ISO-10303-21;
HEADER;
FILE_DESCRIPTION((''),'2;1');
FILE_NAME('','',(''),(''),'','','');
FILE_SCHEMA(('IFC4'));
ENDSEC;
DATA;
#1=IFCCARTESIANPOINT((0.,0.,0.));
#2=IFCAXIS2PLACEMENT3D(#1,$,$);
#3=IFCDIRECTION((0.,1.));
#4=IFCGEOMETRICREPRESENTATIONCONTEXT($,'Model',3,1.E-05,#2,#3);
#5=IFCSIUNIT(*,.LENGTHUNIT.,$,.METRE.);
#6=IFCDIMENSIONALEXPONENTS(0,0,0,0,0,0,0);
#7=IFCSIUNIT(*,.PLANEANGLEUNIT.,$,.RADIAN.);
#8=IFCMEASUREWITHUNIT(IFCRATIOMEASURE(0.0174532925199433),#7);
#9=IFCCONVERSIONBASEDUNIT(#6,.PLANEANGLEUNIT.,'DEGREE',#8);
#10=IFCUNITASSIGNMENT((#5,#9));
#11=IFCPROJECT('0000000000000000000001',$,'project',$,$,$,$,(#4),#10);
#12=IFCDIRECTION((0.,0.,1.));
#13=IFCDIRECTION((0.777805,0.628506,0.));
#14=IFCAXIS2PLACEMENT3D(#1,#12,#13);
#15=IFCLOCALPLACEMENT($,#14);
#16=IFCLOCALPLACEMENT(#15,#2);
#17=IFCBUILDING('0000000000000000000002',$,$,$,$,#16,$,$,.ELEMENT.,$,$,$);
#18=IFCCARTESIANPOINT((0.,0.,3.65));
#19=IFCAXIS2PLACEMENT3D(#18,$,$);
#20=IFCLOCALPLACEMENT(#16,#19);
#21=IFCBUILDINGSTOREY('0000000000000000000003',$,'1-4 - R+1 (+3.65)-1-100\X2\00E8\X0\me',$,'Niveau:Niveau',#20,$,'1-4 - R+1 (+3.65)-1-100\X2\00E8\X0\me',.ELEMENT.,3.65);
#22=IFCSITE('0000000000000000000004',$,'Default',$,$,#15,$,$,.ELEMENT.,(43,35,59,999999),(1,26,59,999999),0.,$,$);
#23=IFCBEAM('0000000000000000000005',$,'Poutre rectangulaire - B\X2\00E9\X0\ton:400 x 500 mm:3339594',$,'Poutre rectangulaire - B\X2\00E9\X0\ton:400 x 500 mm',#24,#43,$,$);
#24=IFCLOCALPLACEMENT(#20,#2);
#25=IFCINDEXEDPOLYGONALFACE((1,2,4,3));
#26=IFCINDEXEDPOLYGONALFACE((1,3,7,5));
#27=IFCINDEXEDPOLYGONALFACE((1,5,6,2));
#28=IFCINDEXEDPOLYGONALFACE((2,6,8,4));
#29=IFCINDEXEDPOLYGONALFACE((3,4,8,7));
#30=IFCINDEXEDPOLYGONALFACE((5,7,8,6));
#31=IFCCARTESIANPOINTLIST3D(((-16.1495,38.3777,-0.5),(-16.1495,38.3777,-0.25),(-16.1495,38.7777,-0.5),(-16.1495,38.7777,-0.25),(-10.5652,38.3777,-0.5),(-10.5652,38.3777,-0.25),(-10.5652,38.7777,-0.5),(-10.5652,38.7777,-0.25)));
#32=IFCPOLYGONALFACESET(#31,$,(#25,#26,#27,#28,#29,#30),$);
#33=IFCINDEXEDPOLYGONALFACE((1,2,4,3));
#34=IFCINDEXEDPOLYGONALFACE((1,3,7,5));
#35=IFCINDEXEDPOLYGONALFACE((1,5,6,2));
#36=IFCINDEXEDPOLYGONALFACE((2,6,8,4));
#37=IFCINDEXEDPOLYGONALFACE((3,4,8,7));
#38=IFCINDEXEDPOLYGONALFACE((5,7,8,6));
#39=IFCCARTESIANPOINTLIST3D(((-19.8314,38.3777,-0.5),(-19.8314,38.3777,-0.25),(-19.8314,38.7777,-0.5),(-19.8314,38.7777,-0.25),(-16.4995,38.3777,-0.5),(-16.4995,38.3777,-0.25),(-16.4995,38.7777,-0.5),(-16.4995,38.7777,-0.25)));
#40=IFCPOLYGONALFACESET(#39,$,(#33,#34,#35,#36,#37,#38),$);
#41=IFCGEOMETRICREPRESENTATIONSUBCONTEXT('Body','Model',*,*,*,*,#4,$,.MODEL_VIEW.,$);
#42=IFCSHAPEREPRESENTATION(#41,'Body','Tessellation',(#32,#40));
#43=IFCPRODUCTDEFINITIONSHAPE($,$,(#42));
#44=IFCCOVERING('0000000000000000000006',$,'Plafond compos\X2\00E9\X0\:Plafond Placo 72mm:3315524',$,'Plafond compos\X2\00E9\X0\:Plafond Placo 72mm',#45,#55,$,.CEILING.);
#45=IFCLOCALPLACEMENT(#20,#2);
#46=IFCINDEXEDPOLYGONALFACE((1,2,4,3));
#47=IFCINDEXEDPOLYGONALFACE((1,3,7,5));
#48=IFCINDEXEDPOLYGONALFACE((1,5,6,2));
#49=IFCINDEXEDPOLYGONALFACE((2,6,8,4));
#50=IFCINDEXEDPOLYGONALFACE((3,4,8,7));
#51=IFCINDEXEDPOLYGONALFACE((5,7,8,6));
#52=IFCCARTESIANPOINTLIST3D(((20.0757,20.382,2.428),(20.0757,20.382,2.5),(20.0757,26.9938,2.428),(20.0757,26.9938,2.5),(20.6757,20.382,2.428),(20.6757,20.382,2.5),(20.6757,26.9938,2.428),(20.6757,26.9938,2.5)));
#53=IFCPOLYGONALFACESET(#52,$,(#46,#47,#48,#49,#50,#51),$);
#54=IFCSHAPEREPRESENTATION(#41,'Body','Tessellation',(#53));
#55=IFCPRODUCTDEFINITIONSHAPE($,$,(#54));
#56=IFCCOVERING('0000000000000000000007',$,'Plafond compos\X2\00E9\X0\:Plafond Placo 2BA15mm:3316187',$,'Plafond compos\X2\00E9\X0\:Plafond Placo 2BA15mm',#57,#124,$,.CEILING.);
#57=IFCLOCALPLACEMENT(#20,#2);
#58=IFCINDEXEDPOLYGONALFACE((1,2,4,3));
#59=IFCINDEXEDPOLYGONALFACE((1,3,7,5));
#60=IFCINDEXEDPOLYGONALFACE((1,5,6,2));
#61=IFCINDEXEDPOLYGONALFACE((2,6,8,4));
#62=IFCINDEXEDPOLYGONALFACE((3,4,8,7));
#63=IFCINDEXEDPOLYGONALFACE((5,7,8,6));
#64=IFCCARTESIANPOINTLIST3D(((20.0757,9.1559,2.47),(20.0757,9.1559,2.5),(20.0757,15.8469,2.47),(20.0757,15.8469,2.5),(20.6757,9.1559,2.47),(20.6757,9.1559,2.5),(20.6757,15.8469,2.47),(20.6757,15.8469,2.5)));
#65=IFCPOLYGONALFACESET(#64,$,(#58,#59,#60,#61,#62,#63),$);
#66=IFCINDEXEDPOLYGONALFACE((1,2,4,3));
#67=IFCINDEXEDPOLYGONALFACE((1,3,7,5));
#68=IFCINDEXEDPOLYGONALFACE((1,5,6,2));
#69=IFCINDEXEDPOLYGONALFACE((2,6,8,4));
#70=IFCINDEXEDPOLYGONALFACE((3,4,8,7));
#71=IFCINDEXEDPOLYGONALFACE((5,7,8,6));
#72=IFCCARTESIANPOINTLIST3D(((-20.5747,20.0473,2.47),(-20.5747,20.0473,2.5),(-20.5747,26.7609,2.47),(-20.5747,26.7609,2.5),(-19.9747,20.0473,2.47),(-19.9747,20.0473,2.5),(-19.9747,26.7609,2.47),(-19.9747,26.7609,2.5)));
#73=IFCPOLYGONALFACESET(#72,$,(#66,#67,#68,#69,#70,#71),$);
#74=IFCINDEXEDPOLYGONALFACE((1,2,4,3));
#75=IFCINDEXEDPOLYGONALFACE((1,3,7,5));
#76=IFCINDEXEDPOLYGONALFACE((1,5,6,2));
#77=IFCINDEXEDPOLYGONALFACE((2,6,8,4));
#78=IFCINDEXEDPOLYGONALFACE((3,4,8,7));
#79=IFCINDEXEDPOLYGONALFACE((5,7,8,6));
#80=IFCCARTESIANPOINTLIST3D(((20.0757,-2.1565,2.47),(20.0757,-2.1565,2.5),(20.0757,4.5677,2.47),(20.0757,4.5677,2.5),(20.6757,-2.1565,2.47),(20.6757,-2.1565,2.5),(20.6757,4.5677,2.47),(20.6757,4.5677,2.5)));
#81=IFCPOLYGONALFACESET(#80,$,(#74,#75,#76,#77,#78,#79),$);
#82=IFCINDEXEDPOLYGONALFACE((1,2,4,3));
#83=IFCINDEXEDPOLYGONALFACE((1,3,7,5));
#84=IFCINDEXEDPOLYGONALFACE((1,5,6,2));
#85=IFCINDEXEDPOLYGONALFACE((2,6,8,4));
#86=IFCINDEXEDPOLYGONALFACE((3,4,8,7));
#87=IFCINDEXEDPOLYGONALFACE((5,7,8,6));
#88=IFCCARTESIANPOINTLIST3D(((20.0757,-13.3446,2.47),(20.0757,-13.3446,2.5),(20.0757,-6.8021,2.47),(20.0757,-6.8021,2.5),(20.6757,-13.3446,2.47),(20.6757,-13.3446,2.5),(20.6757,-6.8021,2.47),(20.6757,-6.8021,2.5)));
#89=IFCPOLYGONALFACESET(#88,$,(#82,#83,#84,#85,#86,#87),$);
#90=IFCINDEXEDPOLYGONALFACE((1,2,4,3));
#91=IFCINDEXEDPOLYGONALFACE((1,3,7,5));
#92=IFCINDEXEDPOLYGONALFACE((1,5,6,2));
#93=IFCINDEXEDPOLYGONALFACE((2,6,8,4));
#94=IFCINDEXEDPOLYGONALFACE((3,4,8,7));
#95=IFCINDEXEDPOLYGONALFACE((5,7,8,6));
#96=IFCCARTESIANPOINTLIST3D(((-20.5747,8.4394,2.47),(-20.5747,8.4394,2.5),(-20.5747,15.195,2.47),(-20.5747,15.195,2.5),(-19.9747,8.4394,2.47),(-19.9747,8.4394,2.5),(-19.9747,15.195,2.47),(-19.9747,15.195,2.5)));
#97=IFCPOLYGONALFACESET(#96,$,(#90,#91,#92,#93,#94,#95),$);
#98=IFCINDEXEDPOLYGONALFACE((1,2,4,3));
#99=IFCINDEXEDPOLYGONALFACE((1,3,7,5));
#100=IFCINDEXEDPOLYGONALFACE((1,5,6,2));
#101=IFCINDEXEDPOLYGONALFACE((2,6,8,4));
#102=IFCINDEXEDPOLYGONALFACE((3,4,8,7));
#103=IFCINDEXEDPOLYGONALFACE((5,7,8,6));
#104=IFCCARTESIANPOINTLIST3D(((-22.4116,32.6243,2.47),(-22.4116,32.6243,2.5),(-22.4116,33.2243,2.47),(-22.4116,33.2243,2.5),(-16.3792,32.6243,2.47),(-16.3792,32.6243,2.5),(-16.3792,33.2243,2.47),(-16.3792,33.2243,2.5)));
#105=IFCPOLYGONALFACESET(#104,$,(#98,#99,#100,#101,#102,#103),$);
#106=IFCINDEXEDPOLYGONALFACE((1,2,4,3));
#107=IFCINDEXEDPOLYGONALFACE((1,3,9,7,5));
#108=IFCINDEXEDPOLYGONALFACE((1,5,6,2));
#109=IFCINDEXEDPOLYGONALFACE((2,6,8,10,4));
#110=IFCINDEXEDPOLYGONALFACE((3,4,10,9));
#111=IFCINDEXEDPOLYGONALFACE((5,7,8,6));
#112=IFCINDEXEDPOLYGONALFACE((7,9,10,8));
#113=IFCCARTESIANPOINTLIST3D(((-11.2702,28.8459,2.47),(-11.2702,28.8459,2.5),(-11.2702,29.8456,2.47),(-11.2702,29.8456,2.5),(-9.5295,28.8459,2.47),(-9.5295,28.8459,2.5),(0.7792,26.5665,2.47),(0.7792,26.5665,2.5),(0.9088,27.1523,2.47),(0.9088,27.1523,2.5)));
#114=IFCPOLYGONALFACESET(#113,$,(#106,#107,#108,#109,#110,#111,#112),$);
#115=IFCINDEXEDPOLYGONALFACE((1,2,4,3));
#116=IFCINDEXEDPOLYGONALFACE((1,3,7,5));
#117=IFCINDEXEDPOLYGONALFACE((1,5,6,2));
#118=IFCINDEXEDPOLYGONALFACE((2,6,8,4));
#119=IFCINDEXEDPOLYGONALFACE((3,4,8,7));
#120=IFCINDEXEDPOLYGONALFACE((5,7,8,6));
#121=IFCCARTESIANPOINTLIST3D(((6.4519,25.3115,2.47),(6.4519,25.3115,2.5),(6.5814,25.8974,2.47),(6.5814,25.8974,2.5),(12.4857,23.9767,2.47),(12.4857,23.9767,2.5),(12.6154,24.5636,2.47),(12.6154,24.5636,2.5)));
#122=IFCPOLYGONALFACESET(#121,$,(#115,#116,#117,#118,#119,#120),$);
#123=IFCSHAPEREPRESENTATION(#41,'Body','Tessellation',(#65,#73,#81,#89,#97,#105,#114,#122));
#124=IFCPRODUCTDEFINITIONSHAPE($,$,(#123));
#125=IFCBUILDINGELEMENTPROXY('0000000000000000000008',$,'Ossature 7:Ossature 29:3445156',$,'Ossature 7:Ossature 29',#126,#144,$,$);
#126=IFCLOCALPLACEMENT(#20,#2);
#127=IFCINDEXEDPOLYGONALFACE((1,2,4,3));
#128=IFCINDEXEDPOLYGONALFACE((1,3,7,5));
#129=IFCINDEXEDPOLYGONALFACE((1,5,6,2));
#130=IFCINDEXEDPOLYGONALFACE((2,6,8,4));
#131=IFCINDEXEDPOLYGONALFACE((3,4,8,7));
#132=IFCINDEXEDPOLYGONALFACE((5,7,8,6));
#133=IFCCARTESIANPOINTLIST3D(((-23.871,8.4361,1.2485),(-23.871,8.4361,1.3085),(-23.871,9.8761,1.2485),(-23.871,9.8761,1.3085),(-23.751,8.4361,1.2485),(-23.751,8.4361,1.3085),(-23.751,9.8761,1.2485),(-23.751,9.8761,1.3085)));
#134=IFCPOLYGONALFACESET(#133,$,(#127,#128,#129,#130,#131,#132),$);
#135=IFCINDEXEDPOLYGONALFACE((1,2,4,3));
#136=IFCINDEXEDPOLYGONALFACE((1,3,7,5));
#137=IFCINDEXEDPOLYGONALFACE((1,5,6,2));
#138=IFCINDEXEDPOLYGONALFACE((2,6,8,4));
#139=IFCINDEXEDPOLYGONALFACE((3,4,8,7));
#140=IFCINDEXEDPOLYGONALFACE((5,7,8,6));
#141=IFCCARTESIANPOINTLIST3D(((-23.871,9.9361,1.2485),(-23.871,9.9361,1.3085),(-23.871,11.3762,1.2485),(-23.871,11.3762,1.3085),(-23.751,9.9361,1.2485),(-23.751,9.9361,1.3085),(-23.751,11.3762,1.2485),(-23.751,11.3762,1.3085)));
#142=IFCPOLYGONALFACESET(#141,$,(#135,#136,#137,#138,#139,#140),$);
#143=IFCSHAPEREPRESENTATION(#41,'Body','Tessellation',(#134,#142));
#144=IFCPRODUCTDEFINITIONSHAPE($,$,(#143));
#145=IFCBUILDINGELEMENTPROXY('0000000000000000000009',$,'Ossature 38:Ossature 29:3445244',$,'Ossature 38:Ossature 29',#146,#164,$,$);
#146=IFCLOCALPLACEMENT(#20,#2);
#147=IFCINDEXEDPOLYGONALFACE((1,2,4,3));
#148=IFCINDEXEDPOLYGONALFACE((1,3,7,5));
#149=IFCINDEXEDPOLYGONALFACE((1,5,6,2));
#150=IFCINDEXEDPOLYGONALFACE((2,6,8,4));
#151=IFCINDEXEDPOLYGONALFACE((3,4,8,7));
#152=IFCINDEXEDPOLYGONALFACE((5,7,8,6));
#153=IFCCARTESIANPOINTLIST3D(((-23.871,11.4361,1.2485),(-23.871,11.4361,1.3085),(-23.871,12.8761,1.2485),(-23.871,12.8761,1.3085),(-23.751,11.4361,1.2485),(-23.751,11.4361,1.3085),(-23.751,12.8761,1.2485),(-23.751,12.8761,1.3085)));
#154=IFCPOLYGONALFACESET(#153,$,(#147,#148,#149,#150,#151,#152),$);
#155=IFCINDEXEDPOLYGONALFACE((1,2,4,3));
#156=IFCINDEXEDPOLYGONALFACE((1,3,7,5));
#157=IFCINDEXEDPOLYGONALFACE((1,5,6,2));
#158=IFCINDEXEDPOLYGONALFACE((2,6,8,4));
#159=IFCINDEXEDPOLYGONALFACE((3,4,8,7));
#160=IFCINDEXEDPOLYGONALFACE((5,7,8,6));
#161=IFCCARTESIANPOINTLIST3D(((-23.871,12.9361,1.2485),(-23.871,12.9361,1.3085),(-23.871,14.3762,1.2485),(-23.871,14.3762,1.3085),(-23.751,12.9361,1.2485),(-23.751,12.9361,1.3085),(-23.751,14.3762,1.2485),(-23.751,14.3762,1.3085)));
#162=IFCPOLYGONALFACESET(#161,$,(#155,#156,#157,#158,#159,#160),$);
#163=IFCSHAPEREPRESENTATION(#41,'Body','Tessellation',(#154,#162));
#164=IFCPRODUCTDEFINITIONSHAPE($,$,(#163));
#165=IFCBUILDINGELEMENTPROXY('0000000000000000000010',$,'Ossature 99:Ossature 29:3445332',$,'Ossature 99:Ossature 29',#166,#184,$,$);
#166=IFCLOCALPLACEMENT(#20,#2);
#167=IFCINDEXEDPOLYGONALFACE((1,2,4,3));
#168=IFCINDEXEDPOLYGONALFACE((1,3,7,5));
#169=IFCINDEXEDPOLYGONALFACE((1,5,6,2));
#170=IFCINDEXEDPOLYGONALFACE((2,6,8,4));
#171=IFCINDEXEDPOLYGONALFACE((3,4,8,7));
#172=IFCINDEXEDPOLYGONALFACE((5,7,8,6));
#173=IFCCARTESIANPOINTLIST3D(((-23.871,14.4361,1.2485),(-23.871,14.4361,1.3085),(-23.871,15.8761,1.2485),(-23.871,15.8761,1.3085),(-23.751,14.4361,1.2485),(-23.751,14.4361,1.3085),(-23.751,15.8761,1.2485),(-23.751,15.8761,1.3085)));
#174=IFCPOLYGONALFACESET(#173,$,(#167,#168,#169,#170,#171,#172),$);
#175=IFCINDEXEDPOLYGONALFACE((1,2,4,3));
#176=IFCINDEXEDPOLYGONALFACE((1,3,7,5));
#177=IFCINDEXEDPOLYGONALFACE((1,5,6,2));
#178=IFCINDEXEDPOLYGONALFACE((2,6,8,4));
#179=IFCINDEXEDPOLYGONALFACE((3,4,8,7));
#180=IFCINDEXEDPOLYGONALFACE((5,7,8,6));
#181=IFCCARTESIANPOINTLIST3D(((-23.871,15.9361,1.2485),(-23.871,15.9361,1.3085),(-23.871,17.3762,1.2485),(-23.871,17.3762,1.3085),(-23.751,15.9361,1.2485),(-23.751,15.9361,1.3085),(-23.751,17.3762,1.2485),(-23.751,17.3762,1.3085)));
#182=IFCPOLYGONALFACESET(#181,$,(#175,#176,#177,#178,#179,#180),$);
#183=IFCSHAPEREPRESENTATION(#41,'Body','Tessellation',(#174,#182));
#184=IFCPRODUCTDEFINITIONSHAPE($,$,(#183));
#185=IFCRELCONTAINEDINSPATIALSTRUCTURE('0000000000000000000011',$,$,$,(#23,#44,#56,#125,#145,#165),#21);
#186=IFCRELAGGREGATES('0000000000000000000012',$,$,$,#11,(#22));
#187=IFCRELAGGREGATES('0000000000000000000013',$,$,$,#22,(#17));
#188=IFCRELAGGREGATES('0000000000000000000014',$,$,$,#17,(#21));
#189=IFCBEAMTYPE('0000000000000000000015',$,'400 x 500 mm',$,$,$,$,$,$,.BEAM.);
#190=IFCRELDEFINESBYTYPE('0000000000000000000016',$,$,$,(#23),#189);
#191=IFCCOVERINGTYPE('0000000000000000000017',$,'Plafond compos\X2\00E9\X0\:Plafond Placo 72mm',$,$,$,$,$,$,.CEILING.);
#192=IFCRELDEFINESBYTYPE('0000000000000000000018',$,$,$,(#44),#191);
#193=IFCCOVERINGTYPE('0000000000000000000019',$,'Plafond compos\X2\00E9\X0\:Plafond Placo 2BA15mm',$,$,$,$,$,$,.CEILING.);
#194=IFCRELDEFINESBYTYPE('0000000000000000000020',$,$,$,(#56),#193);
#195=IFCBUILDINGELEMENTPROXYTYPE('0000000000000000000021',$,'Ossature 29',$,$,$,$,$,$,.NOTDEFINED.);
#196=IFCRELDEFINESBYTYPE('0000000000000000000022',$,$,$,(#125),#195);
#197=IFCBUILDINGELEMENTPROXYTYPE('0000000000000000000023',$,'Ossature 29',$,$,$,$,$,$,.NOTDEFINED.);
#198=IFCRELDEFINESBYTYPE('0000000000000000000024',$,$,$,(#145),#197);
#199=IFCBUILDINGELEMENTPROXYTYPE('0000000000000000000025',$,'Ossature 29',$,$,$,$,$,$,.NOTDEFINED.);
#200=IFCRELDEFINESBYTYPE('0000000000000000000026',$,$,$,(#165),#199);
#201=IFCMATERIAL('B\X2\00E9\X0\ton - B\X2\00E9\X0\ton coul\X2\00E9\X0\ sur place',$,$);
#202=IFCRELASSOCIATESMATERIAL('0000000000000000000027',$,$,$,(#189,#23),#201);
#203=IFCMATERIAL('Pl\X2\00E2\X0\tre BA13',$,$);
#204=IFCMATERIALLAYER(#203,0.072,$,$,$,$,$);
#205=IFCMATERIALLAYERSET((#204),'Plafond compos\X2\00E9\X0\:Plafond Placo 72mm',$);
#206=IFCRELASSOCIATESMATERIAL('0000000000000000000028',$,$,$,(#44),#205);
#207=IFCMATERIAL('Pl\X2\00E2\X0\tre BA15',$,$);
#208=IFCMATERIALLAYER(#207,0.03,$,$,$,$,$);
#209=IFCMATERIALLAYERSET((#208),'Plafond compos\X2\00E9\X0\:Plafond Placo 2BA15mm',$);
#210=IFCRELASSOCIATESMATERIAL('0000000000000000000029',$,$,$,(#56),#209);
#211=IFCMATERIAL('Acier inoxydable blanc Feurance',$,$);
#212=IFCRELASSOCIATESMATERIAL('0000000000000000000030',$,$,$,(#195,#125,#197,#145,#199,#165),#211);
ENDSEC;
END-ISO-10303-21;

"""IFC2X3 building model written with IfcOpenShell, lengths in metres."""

from ifc_helpers import new_model, entity, si_unit, converted_unit, direction, frame, frame_2d, origin, origin_2d_with_axis, place, context, subcontext, project, spatial, polyline, rectangle, outline, extrude, source, transform, mapped, material, layer, layer_set, layer_usage, type_object, type_shapes, element, save


model = new_model("IFC2X3")

# Units and contexts
model_context = context("Model", 3, precision=1e-05, world=origin(), true_north=direction((0.0, 1.0)))
body_context = subcontext(model_context, "Body", "Model", "MODEL_VIEW")
ifc_project = project(units=[si_unit("LENGTHUNIT", "METRE"), converted_unit("PLANEANGLEUNIT", "DEGREE", entity("IfcRatioMeasure", 0.0174532925199433), si_unit("PLANEANGLEUNIT", "RADIAN"), dimensions=[0, 0, 0, 0, 0, 0, 0])], contexts=[model_context])

# Site, building, storey
site_placement = place(None, frame((0.0, 0.0, 0.0), z_axis=(0.0, 0.0, 1.0), x_axis=(0.777805, 0.628506, 0.0)))
site = spatial("IfcSite", under=ifc_project, at=site_placement, Name="Default", CompositionType="ELEMENT", RefLatitude=(43, 35, 59, 999999), RefLongitude=(1, 26, 59, 999999), RefElevation=0.0)
building_placement = place(site_placement, origin())
building = spatial("IfcBuilding", under=site, at=building_placement, CompositionType="ELEMENT")
storey_placement = place(building_placement, frame((0.0, 0.0, 3.65)))
storey = spatial("IfcBuildingStorey", under=building, at=storey_placement, Name="1-4 - R+1 (+3.65)-1-100ème", ObjectType="Niveau:Niveau", LongName="1-4 - R+1 (+3.65)-1-100ème", CompositionType="ELEMENT", Elevation=3.65)

# Beam
ifc_material_1 = material(Name="Béton - Béton coulé sur place")
beam_type = type_object("IfcBeamType", Name="400 x 500 mm", PredefinedType="BEAM", material=ifc_material_1)
shared_shape_1 = source(origin(), body_context, "Body", "SweptSolid", [
    extrude(rectangle(XDim=0.25, YDim=0.4, at=frame_2d((0.0, 0.0), x_axis=(1.0, 0.0))), frame((-10.5652, 38.5777, 3.275), z_axis=(-1.0, 0.0, 0.0), x_axis=(0.0, 0.0, -1.0)), (0.0, 0.0, 1.0), 5.5843),
    extrude(rectangle(XDim=0.25, YDim=0.4, at=frame_2d((0.0, 0.0), x_axis=(1.0, 0.0))), frame((-16.4995, 38.5777, 3.275), z_axis=(-1.0, 0.0, 0.0), x_axis=(0.0, 0.0, -1.0)), (0.0, 0.0, 1.0), 3.3318),
])
type_shapes(beam_type, [shared_shape_1])
beam_placement = place(storey_placement, frame((0.0, 0.0, -3.65)))
element("IfcBeam", 1, at=beam_placement, inside=storey, type_object=beam_type, material=ifc_material_1, Name="Poutre rectangulaire - Béton:400 x 500 mm:3339594", ObjectType="Poutre rectangulaire - Béton:400 x 500 mm", context=body_context, shape_type="MappedRepresentation", body=[
    mapped(shared_shape_1, transform((0.0, 0.0, 0.0), scale=1.0)),
])

# Coverings
ifc_material_2 = material(Name="Plâtre BA13")
ifc_layer_1 = layer(ifc_material_2, 0.072)
ifc_layer_set_1 = layer_set([ifc_layer_1], Name="Plafond composé:Plafond Placo 72mm")
ifc_layer_usage_1 = layer_usage(ifc_layer_set_1, "AXIS3", "POSITIVE", 0.0)
covering_type_1 = type_object("IfcCoveringType", Name="Plafond composé:Plafond Placo 72mm", PredefinedType="CEILING")
covering_1_placement = place(storey_placement, origin())
element("IfcCovering", 2, at=covering_1_placement, inside=storey, type_object=covering_type_1, material=ifc_layer_usage_1, Name="Plafond composé:Plafond Placo 72mm:3315524", ObjectType="Plafond composé:Plafond Placo 72mm", PredefinedType="CEILING", context=body_context, shape_type="SweptSolid", body=[
    extrude(rectangle(XDim=0.6, YDim=6.6118, at=frame_2d((0.0, 0.0), x_axis=(1.0, 0.0))), frame((20.3757, 23.6879, 2.428), z_axis=(0.0, 0.0, 1.0), x_axis=(-1.0, 0.0, 0.0)), (0.0, 0.0, 1.0), 0.072),
])
ifc_material_3 = material(Name="Plâtre BA15")
ifc_layer_2 = layer(ifc_material_3, 0.03)
ifc_layer_set_2 = layer_set([ifc_layer_2], Name="Plafond composé:Plafond Placo 2BA15mm")
ifc_layer_usage_2 = layer_usage(ifc_layer_set_2, "AXIS3", "POSITIVE", 0.0)
covering_type_2 = type_object("IfcCoveringType", Name="Plafond composé:Plafond Placo 2BA15mm", PredefinedType="CEILING")
covering_2_placement = place(storey_placement, origin())
element("IfcCovering", 3, at=covering_2_placement, inside=storey, type_object=covering_type_2, material=ifc_layer_usage_2, Name="Plafond composé:Plafond Placo 2BA15mm:3316187", ObjectType="Plafond composé:Plafond Placo 2BA15mm", PredefinedType="CEILING", context=body_context, shape_type="SweptSolid", body=[
    extrude(rectangle(XDim=0.6, YDim=6.691, at=frame_2d((0.0, 0.0), x_axis=(1.0, 0.0))), frame((20.3757, 12.5014, 2.47), z_axis=(0.0, 0.0, 1.0), x_axis=(-1.0, 0.0, 0.0)), (0.0, 0.0, 1.0), 0.03),
    extrude(rectangle(XDim=0.6, YDim=6.7136, at=frame_2d((-0.0667, 0.0), x_axis=(1.0, 0.0))), frame((-20.3414, 23.4041, 2.47), z_axis=(0.0, 0.0, 1.0), x_axis=(-1.0, 0.0, 0.0)), (0.0, 0.0, 1.0), 0.03),
    extrude(rectangle(XDim=0.6, YDim=6.7241, at=origin_2d_with_axis()), frame((20.3757, 1.2056, 2.47), z_axis=(0.0, 0.0, 1.0), x_axis=(-1.0, 0.0, 0.0)), (0.0, 0.0, 1.0), 0.03),
    extrude(rectangle(XDim=0.6, YDim=6.5425, at=origin_2d_with_axis()), frame((20.3757, -10.0733, 2.47), z_axis=(0.0, 0.0, 1.0), x_axis=(-1.0, 0.0, 0.0)), (0.0, 0.0, 1.0), 0.03),
    extrude(rectangle(XDim=0.6, YDim=6.7556, at=frame_2d((0.0, 0.0), x_axis=(1.0, 0.0))), frame((-20.2747, 11.8172, 2.47), z_axis=(0.0, 0.0, 1.0), x_axis=(-1.0, 0.0, 0.0)), (0.0, 0.0, 1.0), 0.03),
    extrude(rectangle(XDim=6.0325, YDim=0.6, at=origin_2d_with_axis()), frame((-19.3954, 32.9243, 2.47), z_axis=(0.0, 0.0, 1.0), x_axis=(-1.0, 0.0, 0.0)), (0.0, 0.0, 1.0), 0.03),
    extrude(outline(polyline([(-7.0577, -0.4353), (5.4155, -0.4353), (5.1997, 0.5409), (3.5, 0.165), (-7.0576, 0.1647), (-7.0577, -0.4353)])), frame((-6.0764, 28.2513, 2.47), z_axis=(0.0, 0.0, 1.0), x_axis=(-0.976409, 0.215927, 0.0)), (0.0, 0.0, 1.0), 0.03),
    extrude(outline(polyline([(-0.3003, -3.0898), (0.2998, -3.0898), (0.3008, 3.0898), (-0.3003, 3.0898), (-0.3003, -3.0898)])), frame((9.5336, 24.9373, 2.47), z_axis=(0.0, 0.0, 1.0), x_axis=(-0.215845, -0.976428, 0.0)), (0.0, 0.0, 1.0), 0.03),
])

# Building element proxies
ifc_material_4 = material(Name="Acier inoxydable blanc Feurance")
building_element_proxy_type_1 = type_object("IfcBuildingElementProxyType", Name="Ossature 29", PredefinedType="NOTDEFINED", material=ifc_material_4)
shared_shape_2 = source(origin(), body_context, "Body", "SweptSolid", [
    extrude(rectangle(XDim=1.44, YDim=0.12, at=frame_2d((0.0, 0.0), x_axis=(1.0, 0.0))), frame((-23.811, 9.1561, 4.67), z_axis=(0.0, 0.0, 1.0), x_axis=(0.0, -1.0, 0.0)), (0.0, 0.0, 1.0), 0.06),
    extrude(rectangle(XDim=1.44, YDim=0.12, at=frame_2d((0.0, 0.0), x_axis=(1.0, 0.0))), frame((-23.811, 10.6561, 4.67), z_axis=(0.0, 0.0, 1.0), x_axis=(0.0, -1.0, 0.0)), (0.0, 0.0, 1.0), 0.06),
])
type_shapes(building_element_proxy_type_1, [shared_shape_2])
proxy_1_placement = place(storey_placement, frame((0.0, 0.0, -3.4215)))
element("IfcBuildingElementProxy", 4, at=proxy_1_placement, inside=storey, type_object=building_element_proxy_type_1, material=ifc_material_4, Name="Ossature 7:Ossature 29:3445156", ObjectType="Ossature 7:Ossature 29", context=body_context, shape_type="MappedRepresentation", body=[
    mapped(shared_shape_2, transform((0.0, 0.0, 0.0), scale=1.0)),
])
building_element_proxy_type_2 = type_object("IfcBuildingElementProxyType", Name="Ossature 29", PredefinedType="NOTDEFINED", material=ifc_material_4)
shared_shape_3 = source(origin(), body_context, "Body", "SweptSolid", [
    extrude(rectangle(XDim=1.44, YDim=0.12, at=frame_2d((0.0, 0.0), x_axis=(1.0, 0.0))), frame((-23.811, 12.1561, 4.67), z_axis=(0.0, 0.0, 1.0), x_axis=(0.0, -1.0, 0.0)), (0.0, 0.0, 1.0), 0.06),
    extrude(rectangle(XDim=1.44, YDim=0.12, at=frame_2d((0.0, 0.0), x_axis=(1.0, 0.0))), frame((-23.811, 13.6561, 4.67), z_axis=(0.0, 0.0, 1.0), x_axis=(0.0, -1.0, 0.0)), (0.0, 0.0, 1.0), 0.06),
])
type_shapes(building_element_proxy_type_2, [shared_shape_3])
proxy_2_placement = place(storey_placement, frame((0.0, 0.0, -3.4215)))
element("IfcBuildingElementProxy", 5, at=proxy_2_placement, inside=storey, type_object=building_element_proxy_type_2, material=ifc_material_4, Name="Ossature 38:Ossature 29:3445244", ObjectType="Ossature 38:Ossature 29", context=body_context, shape_type="MappedRepresentation", body=[
    mapped(shared_shape_3, transform((0.0, 0.0, 0.0), scale=1.0)),
])
building_element_proxy_type_3 = type_object("IfcBuildingElementProxyType", Name="Ossature 29", PredefinedType="NOTDEFINED", material=ifc_material_4)
shared_shape_4 = source(origin(), body_context, "Body", "SweptSolid", [
    extrude(rectangle(XDim=1.44, YDim=0.12, at=frame_2d((0.0, 0.0), x_axis=(1.0, 0.0))), frame((-23.811, 15.1561, 4.67), z_axis=(0.0, 0.0, 1.0), x_axis=(0.0, -1.0, 0.0)), (0.0, 0.0, 1.0), 0.06),
    extrude(rectangle(XDim=1.44, YDim=0.12, at=frame_2d((0.0, 0.0), x_axis=(1.0, 0.0))), frame((-23.811, 16.6561, 4.67), z_axis=(0.0, 0.0, 1.0), x_axis=(0.0, -1.0, 0.0)), (0.0, 0.0, 1.0), 0.06),
])
type_shapes(building_element_proxy_type_3, [shared_shape_4])
proxy_3_placement = place(storey_placement, frame((0.0, 0.0, -3.4215)))
element("IfcBuildingElementProxy", 6, at=proxy_3_placement, inside=storey, type_object=building_element_proxy_type_3, material=ifc_material_4, Name="Ossature 99:Ossature 29:3445332", ObjectType="Ossature 99:Ossature 29", context=body_context, shape_type="MappedRepresentation", body=[
    mapped(shared_shape_4, transform((0.0, 0.0, 0.0), scale=1.0)),
])

save(model, "model.ifc")
